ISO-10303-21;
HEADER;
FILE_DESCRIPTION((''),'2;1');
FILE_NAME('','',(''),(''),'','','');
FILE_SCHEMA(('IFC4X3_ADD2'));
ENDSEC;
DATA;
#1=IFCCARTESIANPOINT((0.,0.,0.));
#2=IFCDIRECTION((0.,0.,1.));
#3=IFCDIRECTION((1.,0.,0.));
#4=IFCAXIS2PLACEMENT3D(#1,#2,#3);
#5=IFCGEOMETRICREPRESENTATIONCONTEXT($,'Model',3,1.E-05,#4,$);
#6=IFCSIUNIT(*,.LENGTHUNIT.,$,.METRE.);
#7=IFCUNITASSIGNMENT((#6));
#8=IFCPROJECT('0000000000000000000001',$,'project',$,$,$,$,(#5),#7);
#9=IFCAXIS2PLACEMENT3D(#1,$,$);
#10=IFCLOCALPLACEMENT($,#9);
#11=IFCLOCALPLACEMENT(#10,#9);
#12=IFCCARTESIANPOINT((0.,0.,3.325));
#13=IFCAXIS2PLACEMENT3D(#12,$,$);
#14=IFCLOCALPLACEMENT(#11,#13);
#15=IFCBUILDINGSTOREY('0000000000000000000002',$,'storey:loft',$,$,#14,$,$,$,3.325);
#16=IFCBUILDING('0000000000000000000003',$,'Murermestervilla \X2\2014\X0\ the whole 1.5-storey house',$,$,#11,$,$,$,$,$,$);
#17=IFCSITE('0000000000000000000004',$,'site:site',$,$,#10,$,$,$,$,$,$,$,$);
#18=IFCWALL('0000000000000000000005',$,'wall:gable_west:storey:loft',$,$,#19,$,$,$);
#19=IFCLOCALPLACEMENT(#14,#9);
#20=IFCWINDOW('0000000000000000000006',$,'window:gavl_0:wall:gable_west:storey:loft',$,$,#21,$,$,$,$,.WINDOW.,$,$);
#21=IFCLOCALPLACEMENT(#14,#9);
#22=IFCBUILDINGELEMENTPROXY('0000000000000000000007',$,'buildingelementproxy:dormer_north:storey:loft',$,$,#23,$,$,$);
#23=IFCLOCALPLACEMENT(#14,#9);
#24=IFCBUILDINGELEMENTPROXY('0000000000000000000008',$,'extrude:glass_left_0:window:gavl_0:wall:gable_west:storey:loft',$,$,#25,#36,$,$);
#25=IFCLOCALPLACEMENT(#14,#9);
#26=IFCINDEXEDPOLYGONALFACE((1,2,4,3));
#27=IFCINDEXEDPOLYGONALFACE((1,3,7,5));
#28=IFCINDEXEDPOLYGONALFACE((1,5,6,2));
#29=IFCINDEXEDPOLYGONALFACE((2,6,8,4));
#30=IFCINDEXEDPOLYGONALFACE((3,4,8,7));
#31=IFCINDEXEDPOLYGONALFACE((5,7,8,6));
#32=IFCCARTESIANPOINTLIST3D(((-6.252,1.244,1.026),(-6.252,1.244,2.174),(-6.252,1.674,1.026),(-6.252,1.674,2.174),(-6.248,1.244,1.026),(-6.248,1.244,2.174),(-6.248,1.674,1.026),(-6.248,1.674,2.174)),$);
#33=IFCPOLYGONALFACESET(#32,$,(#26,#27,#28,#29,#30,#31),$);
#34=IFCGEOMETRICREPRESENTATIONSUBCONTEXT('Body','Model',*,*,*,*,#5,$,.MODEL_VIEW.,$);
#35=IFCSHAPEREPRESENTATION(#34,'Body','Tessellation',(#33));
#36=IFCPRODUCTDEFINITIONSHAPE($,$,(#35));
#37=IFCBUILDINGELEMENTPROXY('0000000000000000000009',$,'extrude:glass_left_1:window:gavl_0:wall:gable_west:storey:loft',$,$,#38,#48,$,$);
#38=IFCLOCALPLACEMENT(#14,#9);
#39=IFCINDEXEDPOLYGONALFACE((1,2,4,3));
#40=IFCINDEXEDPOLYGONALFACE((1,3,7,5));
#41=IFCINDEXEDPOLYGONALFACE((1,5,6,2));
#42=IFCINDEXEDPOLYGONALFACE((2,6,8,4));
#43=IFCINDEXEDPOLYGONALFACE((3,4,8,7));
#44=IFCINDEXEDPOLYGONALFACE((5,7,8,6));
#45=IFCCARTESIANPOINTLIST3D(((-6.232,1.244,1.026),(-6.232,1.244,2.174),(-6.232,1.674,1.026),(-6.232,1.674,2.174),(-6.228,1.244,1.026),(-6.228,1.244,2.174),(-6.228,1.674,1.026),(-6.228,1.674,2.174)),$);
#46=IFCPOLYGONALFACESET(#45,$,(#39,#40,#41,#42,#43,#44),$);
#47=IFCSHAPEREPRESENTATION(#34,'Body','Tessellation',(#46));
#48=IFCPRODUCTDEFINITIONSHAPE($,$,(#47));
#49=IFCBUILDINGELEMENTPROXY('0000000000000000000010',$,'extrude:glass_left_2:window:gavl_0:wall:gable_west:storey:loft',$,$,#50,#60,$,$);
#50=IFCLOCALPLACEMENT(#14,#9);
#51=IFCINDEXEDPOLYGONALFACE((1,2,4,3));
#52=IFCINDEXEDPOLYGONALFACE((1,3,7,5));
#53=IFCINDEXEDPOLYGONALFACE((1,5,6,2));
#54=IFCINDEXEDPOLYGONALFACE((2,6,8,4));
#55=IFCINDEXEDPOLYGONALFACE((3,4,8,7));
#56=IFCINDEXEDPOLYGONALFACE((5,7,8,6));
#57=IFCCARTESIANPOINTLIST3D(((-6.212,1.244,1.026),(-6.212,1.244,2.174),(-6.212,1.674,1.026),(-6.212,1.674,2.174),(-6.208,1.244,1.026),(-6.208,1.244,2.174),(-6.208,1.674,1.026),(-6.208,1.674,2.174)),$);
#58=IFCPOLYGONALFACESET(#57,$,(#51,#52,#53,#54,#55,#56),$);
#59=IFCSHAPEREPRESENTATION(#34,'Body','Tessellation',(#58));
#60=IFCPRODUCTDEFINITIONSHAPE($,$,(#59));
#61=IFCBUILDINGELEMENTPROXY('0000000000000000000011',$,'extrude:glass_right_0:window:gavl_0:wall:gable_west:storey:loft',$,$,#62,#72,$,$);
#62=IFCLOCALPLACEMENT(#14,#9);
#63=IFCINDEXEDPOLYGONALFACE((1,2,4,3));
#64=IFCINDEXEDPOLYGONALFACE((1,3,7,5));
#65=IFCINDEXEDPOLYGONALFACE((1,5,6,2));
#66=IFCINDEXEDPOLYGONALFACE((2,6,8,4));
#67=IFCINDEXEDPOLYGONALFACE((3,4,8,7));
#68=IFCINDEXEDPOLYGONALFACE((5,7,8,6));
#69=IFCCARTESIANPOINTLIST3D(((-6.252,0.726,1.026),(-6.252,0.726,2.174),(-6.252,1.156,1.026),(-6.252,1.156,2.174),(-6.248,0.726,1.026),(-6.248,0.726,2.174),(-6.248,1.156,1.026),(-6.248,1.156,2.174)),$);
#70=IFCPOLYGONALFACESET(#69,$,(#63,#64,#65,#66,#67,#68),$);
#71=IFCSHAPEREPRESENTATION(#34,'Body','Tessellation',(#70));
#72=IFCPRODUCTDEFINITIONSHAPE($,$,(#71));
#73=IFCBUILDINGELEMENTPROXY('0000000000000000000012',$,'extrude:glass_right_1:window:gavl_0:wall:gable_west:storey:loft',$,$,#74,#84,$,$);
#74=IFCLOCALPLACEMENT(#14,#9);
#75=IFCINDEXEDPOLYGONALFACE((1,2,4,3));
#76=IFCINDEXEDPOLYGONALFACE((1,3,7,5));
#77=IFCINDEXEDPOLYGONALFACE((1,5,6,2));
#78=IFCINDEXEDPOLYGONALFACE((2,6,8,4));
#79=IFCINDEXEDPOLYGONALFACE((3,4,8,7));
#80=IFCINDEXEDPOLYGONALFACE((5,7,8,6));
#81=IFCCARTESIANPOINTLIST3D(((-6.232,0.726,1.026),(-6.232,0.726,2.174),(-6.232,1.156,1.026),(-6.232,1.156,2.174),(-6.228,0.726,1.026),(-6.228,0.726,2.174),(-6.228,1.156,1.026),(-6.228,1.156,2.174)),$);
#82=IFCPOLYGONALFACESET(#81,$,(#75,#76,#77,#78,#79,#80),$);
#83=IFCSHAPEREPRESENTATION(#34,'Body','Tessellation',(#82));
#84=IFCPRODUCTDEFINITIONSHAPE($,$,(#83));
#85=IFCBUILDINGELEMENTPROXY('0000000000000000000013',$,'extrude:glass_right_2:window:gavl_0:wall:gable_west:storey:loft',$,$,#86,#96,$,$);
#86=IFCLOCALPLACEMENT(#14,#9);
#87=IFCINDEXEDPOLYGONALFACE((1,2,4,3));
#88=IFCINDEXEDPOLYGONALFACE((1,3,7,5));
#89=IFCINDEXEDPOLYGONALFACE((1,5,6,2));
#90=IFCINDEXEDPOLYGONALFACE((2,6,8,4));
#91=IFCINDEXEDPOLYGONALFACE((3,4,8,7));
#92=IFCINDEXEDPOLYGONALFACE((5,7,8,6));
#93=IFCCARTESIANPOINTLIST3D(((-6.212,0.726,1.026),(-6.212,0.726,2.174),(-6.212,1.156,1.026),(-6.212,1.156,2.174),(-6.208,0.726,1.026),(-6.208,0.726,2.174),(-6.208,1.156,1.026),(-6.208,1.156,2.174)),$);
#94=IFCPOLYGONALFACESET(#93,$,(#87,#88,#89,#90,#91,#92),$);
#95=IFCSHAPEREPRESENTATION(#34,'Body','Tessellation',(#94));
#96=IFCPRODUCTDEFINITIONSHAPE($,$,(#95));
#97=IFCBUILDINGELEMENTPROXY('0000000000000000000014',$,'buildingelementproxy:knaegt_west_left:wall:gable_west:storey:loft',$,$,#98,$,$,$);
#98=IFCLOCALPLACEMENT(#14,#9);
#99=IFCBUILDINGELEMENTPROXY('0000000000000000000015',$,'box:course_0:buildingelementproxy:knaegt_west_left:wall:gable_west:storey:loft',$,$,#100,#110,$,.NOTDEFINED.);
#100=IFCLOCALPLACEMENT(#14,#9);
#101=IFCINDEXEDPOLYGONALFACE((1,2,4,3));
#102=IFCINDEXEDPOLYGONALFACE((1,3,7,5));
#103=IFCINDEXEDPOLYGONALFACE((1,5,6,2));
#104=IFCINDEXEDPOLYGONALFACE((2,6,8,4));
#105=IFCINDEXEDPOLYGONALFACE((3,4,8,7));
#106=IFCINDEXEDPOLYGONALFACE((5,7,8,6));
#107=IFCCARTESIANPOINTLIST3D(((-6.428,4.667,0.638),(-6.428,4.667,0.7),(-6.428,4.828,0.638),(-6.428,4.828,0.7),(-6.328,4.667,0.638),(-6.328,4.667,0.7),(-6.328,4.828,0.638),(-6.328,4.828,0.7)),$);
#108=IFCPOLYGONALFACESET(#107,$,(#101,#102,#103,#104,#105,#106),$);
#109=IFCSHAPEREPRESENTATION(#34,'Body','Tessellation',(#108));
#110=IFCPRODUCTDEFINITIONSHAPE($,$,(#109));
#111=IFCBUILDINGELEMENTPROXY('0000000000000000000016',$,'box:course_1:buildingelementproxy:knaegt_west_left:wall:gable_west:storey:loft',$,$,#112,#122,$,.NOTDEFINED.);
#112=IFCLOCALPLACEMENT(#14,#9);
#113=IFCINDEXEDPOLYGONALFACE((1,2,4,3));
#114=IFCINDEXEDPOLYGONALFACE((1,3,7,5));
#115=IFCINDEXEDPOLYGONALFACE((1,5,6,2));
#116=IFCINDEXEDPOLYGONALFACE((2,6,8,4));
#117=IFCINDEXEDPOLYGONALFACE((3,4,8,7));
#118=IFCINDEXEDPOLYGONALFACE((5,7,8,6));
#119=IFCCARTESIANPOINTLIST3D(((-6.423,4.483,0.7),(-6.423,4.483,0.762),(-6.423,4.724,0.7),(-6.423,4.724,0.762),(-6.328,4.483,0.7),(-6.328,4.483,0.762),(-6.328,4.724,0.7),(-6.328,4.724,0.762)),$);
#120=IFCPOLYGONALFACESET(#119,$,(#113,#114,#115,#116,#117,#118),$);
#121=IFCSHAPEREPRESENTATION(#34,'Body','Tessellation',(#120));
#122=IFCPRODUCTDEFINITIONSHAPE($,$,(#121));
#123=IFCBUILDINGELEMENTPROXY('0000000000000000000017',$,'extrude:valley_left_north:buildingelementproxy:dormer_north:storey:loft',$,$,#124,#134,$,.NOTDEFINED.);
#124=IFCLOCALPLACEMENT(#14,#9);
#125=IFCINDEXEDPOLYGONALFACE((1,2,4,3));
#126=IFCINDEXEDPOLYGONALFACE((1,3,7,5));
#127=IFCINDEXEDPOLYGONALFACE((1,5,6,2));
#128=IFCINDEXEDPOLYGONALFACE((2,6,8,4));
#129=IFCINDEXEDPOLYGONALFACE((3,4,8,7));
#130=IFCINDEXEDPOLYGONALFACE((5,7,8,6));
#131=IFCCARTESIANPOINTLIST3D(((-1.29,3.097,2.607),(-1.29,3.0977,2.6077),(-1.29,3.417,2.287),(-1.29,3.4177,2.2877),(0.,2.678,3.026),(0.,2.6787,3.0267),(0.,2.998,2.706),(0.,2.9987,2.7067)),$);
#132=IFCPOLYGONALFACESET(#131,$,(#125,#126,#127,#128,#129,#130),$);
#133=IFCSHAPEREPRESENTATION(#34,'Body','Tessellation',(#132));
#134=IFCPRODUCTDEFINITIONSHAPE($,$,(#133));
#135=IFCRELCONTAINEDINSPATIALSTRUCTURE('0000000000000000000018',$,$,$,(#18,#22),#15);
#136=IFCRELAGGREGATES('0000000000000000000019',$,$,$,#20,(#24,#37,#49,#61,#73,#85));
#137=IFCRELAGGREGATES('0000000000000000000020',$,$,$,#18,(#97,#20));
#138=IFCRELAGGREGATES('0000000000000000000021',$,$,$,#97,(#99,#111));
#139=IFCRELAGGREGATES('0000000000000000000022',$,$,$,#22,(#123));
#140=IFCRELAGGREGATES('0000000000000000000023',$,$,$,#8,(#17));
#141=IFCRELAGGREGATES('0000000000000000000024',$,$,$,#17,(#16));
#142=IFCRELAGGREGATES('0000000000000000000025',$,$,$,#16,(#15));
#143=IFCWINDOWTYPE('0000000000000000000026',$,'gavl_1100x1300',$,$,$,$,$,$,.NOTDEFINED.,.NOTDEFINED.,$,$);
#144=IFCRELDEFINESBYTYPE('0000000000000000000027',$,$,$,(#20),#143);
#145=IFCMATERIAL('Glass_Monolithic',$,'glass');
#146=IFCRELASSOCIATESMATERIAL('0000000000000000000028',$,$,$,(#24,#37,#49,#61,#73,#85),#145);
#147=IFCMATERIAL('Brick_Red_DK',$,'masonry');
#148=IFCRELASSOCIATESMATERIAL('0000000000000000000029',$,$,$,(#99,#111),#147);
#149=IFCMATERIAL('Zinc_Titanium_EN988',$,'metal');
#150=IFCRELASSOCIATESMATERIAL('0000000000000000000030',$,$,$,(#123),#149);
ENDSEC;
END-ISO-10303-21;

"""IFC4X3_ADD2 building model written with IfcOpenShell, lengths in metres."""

from ifc_helpers import new_model, si_unit, frame, origin, origin_with_axes, place, context, subcontext, project, spatial, polyline, rectangle, outline, extrude, source, transform, mapped, material, type_object, element, aggregate, save


model = new_model("IFC4X3_ADD2")

# Units and contexts
model_context = context("Model", 3, precision=1e-05, world=origin_with_axes())
body_context = subcontext(model_context, "Body", "Model", "MODEL_VIEW")
ifc_project = project(units=[si_unit("LENGTHUNIT", "METRE")], contexts=[model_context])

# Site, building, storey
placement_1 = place(None, origin())
site = spatial("IfcSite", under=ifc_project, at=placement_1, Name="site:site")
building_placement = place(placement_1, origin())
building = spatial("IfcBuilding", under=site, at=building_placement, Name="Murermestervilla — the whole 1.5-storey house")
storey_placement = place(building_placement, frame((0.0, 0.0, 3.325)))
storey = spatial("IfcBuildingStorey", under=building, at=storey_placement, Name="storey:loft", Elevation=3.325)

# Wall, window
placement_2 = place(storey_placement, frame((0.0, 0.0, -3.325)))
wall_1 = element("IfcWall", 1, at=placement_2, inside=storey, Name="wall:gable_west:storey:loft")
window_type_1 = type_object("IfcWindowType", Name="gavl_1100x1300", PartitioningType="NOTDEFINED", PredefinedType="NOTDEFINED")
window_1_placement = place(None, frame((-6.328, 1.2, 4.275), z_axis=(0.0, 0.0, 1.0), x_axis=(0.0, -1.0, 0.0)))
window_1 = element("IfcWindow", 2, at=window_1_placement, type_object=window_type_1, Name="window:gavl_0:wall:gable_west:storey:loft", PredefinedType="WINDOW")

# Building element proxy
proxy_1 = element("IfcBuildingElementProxy", 3, at=placement_2, inside=storey, Name="buildingelementproxy:dormer_north:storey:loft")
ifc_material_1 = material(Name="Zinc_Titanium_EN988", Category="metal")

# Building element proxies
ifc_material_2 = material(Name="Glass_Monolithic", Category="glass")
shared_shape_1 = source(origin(), body_context, "Body", "SweptSolid", [
    extrude(outline(polyline([(-0.215, -0.574), (0.215, -0.574), (0.215, 0.574), (-0.215, 0.574), (-0.215, -0.574)])), frame((0.0, 0.0, -0.002)), (0.0, 0.0, 1.0), 0.004),
])
proxy_2_placement = place(None, frame((-6.25, 1.459, 4.925), z_axis=(-1.0, 0.0, 0.0), x_axis=(0.0, -1.0, 0.0)))
proxy_2 = element("IfcBuildingElementProxy", 4, at=proxy_2_placement, material=ifc_material_2, Name="extrude:glass_left_0:window:gavl_0:wall:gable_west:storey:loft", context=body_context, shape_type="MappedRepresentation", body=[
    mapped(shared_shape_1, transform((0.0, 0.0, 0.0))),
])
shared_shape_2 = source(origin(), body_context, "Body", "SweptSolid", [
    extrude(outline(polyline([(-0.215, -0.574), (0.215, -0.574), (0.215, 0.574), (-0.215, 0.574), (-0.215, -0.574)])), frame((0.0, 0.0, -0.002)), (0.0, 0.0, 1.0), 0.004),
])
proxy_3_placement = place(None, frame((-6.23, 1.459, 4.925), z_axis=(-1.0, 0.0, 0.0), x_axis=(0.0, -1.0, 0.0)))
proxy_3 = element("IfcBuildingElementProxy", 5, at=proxy_3_placement, material=ifc_material_2, Name="extrude:glass_left_1:window:gavl_0:wall:gable_west:storey:loft", context=body_context, shape_type="MappedRepresentation", body=[
    mapped(shared_shape_2, transform((0.0, 0.0, 0.0))),
])
shared_shape_3 = source(origin(), body_context, "Body", "SweptSolid", [
    extrude(outline(polyline([(-0.215, -0.574), (0.215, -0.574), (0.215, 0.574), (-0.215, 0.574), (-0.215, -0.574)])), frame((0.0, 0.0, -0.002)), (0.0, 0.0, 1.0), 0.004),
])
proxy_4_placement = place(None, frame((-6.21, 1.459, 4.925), z_axis=(-1.0, 0.0, 0.0), x_axis=(0.0, -1.0, 0.0)))
proxy_4 = element("IfcBuildingElementProxy", 6, at=proxy_4_placement, material=ifc_material_2, Name="extrude:glass_left_2:window:gavl_0:wall:gable_west:storey:loft", context=body_context, shape_type="MappedRepresentation", body=[
    mapped(shared_shape_3, transform((0.0, 0.0, 0.0))),
])
shared_shape_4 = source(origin(), body_context, "Body", "SweptSolid", [
    extrude(outline(polyline([(-0.215, -0.574), (0.215, -0.574), (0.215, 0.574), (-0.215, 0.574), (-0.215, -0.574)])), frame((0.0, 0.0, -0.002)), (0.0, 0.0, 1.0), 0.004),
])
proxy_5_placement = place(None, frame((-6.25, 0.941, 4.925), z_axis=(-1.0, 0.0, 0.0), x_axis=(0.0, -1.0, 0.0)))
proxy_5 = element("IfcBuildingElementProxy", 7, at=proxy_5_placement, material=ifc_material_2, Name="extrude:glass_right_0:window:gavl_0:wall:gable_west:storey:loft", context=body_context, shape_type="MappedRepresentation", body=[
    mapped(shared_shape_4, transform((0.0, 0.0, 0.0))),
])
shared_shape_5 = source(origin(), body_context, "Body", "SweptSolid", [
    extrude(outline(polyline([(-0.215, -0.574), (0.215, -0.574), (0.215, 0.574), (-0.215, 0.574), (-0.215, -0.574)])), frame((0.0, 0.0, -0.002)), (0.0, 0.0, 1.0), 0.004),
])
proxy_6_placement = place(None, frame((-6.23, 0.941, 4.925), z_axis=(-1.0, 0.0, 0.0), x_axis=(0.0, -1.0, 0.0)))
proxy_6 = element("IfcBuildingElementProxy", 8, at=proxy_6_placement, material=ifc_material_2, Name="extrude:glass_right_1:window:gavl_0:wall:gable_west:storey:loft", context=body_context, shape_type="MappedRepresentation", body=[
    mapped(shared_shape_5, transform((0.0, 0.0, 0.0))),
])
shared_shape_6 = source(origin(), body_context, "Body", "SweptSolid", [
    extrude(outline(polyline([(-0.215, -0.574), (0.215, -0.574), (0.215, 0.574), (-0.215, 0.574), (-0.215, -0.574)])), frame((0.0, 0.0, -0.002)), (0.0, 0.0, 1.0), 0.004),
])
proxy_7_placement = place(None, frame((-6.21, 0.941, 4.925), z_axis=(-1.0, 0.0, 0.0), x_axis=(0.0, -1.0, 0.0)))
proxy_7 = element("IfcBuildingElementProxy", 9, at=proxy_7_placement, material=ifc_material_2, Name="extrude:glass_right_2:window:gavl_0:wall:gable_west:storey:loft", context=body_context, shape_type="MappedRepresentation", body=[
    mapped(shared_shape_6, transform((0.0, 0.0, 0.0))),
])
aggregate(window_1, [proxy_2, proxy_3, proxy_4, proxy_5, proxy_6, proxy_7])
proxy_8 = element("IfcBuildingElementProxy", 10, at=placement_1, Name="buildingelementproxy:knaegt_west_left:wall:gable_west:storey:loft")
aggregate(wall_1, [proxy_8, window_1])
ifc_material_3 = material(Name="Brick_Red_DK", Category="masonry")
proxy_9_placement = place(None, frame((-6.378, 4.7475, 3.994)))
proxy_9 = element("IfcBuildingElementProxy", 11, at=proxy_9_placement, material=ifc_material_3, Name="box:course_0:buildingelementproxy:knaegt_west_left:wall:gable_west:storey:loft", PredefinedType="NOTDEFINED", context=body_context, shape_type="SweptSolid", body=[
    extrude(rectangle(XDim=0.1, YDim=0.161), frame((0.0, 0.0, -0.031)), (0.0, 0.0, 1.0), 0.062),
])
proxy_10_placement = place(None, frame((-6.3755, 4.6035, 4.056)))
proxy_10 = element("IfcBuildingElementProxy", 12, at=proxy_10_placement, material=ifc_material_3, Name="box:course_1:buildingelementproxy:knaegt_west_left:wall:gable_west:storey:loft", PredefinedType="NOTDEFINED", context=body_context, shape_type="SweptSolid", body=[
    extrude(rectangle(XDim=0.095, YDim=0.241), frame((0.0, 0.0, -0.031)), (0.0, 0.0, 1.0), 0.062),
])
aggregate(proxy_8, [proxy_9, proxy_10])
proxy_11_placement = place(None, frame((-0.645, 3.0475, 5.9815), z_axis=(0.0, 0.707107, 0.707107), x_axis=(-1.0, 0.0, 0.0)))
proxy_11 = element("IfcBuildingElementProxy", 13, at=proxy_11_placement, material=ifc_material_1, Name="extrude:valley_left_north:buildingelementproxy:dormer_north:storey:loft", PredefinedType="NOTDEFINED", context=body_context, shape_type="SweptSolid", body=[
    extrude(outline(polyline([(0.645, -0.07), (0.645, -0.5226), (-0.645, 0.07), (-0.645, 0.5226), (0.645, -0.07)])), origin(), (0.0, 0.0, 1.0), 0.001),
])
aggregate(proxy_1, [proxy_11])

save(model, "model.ifc")
